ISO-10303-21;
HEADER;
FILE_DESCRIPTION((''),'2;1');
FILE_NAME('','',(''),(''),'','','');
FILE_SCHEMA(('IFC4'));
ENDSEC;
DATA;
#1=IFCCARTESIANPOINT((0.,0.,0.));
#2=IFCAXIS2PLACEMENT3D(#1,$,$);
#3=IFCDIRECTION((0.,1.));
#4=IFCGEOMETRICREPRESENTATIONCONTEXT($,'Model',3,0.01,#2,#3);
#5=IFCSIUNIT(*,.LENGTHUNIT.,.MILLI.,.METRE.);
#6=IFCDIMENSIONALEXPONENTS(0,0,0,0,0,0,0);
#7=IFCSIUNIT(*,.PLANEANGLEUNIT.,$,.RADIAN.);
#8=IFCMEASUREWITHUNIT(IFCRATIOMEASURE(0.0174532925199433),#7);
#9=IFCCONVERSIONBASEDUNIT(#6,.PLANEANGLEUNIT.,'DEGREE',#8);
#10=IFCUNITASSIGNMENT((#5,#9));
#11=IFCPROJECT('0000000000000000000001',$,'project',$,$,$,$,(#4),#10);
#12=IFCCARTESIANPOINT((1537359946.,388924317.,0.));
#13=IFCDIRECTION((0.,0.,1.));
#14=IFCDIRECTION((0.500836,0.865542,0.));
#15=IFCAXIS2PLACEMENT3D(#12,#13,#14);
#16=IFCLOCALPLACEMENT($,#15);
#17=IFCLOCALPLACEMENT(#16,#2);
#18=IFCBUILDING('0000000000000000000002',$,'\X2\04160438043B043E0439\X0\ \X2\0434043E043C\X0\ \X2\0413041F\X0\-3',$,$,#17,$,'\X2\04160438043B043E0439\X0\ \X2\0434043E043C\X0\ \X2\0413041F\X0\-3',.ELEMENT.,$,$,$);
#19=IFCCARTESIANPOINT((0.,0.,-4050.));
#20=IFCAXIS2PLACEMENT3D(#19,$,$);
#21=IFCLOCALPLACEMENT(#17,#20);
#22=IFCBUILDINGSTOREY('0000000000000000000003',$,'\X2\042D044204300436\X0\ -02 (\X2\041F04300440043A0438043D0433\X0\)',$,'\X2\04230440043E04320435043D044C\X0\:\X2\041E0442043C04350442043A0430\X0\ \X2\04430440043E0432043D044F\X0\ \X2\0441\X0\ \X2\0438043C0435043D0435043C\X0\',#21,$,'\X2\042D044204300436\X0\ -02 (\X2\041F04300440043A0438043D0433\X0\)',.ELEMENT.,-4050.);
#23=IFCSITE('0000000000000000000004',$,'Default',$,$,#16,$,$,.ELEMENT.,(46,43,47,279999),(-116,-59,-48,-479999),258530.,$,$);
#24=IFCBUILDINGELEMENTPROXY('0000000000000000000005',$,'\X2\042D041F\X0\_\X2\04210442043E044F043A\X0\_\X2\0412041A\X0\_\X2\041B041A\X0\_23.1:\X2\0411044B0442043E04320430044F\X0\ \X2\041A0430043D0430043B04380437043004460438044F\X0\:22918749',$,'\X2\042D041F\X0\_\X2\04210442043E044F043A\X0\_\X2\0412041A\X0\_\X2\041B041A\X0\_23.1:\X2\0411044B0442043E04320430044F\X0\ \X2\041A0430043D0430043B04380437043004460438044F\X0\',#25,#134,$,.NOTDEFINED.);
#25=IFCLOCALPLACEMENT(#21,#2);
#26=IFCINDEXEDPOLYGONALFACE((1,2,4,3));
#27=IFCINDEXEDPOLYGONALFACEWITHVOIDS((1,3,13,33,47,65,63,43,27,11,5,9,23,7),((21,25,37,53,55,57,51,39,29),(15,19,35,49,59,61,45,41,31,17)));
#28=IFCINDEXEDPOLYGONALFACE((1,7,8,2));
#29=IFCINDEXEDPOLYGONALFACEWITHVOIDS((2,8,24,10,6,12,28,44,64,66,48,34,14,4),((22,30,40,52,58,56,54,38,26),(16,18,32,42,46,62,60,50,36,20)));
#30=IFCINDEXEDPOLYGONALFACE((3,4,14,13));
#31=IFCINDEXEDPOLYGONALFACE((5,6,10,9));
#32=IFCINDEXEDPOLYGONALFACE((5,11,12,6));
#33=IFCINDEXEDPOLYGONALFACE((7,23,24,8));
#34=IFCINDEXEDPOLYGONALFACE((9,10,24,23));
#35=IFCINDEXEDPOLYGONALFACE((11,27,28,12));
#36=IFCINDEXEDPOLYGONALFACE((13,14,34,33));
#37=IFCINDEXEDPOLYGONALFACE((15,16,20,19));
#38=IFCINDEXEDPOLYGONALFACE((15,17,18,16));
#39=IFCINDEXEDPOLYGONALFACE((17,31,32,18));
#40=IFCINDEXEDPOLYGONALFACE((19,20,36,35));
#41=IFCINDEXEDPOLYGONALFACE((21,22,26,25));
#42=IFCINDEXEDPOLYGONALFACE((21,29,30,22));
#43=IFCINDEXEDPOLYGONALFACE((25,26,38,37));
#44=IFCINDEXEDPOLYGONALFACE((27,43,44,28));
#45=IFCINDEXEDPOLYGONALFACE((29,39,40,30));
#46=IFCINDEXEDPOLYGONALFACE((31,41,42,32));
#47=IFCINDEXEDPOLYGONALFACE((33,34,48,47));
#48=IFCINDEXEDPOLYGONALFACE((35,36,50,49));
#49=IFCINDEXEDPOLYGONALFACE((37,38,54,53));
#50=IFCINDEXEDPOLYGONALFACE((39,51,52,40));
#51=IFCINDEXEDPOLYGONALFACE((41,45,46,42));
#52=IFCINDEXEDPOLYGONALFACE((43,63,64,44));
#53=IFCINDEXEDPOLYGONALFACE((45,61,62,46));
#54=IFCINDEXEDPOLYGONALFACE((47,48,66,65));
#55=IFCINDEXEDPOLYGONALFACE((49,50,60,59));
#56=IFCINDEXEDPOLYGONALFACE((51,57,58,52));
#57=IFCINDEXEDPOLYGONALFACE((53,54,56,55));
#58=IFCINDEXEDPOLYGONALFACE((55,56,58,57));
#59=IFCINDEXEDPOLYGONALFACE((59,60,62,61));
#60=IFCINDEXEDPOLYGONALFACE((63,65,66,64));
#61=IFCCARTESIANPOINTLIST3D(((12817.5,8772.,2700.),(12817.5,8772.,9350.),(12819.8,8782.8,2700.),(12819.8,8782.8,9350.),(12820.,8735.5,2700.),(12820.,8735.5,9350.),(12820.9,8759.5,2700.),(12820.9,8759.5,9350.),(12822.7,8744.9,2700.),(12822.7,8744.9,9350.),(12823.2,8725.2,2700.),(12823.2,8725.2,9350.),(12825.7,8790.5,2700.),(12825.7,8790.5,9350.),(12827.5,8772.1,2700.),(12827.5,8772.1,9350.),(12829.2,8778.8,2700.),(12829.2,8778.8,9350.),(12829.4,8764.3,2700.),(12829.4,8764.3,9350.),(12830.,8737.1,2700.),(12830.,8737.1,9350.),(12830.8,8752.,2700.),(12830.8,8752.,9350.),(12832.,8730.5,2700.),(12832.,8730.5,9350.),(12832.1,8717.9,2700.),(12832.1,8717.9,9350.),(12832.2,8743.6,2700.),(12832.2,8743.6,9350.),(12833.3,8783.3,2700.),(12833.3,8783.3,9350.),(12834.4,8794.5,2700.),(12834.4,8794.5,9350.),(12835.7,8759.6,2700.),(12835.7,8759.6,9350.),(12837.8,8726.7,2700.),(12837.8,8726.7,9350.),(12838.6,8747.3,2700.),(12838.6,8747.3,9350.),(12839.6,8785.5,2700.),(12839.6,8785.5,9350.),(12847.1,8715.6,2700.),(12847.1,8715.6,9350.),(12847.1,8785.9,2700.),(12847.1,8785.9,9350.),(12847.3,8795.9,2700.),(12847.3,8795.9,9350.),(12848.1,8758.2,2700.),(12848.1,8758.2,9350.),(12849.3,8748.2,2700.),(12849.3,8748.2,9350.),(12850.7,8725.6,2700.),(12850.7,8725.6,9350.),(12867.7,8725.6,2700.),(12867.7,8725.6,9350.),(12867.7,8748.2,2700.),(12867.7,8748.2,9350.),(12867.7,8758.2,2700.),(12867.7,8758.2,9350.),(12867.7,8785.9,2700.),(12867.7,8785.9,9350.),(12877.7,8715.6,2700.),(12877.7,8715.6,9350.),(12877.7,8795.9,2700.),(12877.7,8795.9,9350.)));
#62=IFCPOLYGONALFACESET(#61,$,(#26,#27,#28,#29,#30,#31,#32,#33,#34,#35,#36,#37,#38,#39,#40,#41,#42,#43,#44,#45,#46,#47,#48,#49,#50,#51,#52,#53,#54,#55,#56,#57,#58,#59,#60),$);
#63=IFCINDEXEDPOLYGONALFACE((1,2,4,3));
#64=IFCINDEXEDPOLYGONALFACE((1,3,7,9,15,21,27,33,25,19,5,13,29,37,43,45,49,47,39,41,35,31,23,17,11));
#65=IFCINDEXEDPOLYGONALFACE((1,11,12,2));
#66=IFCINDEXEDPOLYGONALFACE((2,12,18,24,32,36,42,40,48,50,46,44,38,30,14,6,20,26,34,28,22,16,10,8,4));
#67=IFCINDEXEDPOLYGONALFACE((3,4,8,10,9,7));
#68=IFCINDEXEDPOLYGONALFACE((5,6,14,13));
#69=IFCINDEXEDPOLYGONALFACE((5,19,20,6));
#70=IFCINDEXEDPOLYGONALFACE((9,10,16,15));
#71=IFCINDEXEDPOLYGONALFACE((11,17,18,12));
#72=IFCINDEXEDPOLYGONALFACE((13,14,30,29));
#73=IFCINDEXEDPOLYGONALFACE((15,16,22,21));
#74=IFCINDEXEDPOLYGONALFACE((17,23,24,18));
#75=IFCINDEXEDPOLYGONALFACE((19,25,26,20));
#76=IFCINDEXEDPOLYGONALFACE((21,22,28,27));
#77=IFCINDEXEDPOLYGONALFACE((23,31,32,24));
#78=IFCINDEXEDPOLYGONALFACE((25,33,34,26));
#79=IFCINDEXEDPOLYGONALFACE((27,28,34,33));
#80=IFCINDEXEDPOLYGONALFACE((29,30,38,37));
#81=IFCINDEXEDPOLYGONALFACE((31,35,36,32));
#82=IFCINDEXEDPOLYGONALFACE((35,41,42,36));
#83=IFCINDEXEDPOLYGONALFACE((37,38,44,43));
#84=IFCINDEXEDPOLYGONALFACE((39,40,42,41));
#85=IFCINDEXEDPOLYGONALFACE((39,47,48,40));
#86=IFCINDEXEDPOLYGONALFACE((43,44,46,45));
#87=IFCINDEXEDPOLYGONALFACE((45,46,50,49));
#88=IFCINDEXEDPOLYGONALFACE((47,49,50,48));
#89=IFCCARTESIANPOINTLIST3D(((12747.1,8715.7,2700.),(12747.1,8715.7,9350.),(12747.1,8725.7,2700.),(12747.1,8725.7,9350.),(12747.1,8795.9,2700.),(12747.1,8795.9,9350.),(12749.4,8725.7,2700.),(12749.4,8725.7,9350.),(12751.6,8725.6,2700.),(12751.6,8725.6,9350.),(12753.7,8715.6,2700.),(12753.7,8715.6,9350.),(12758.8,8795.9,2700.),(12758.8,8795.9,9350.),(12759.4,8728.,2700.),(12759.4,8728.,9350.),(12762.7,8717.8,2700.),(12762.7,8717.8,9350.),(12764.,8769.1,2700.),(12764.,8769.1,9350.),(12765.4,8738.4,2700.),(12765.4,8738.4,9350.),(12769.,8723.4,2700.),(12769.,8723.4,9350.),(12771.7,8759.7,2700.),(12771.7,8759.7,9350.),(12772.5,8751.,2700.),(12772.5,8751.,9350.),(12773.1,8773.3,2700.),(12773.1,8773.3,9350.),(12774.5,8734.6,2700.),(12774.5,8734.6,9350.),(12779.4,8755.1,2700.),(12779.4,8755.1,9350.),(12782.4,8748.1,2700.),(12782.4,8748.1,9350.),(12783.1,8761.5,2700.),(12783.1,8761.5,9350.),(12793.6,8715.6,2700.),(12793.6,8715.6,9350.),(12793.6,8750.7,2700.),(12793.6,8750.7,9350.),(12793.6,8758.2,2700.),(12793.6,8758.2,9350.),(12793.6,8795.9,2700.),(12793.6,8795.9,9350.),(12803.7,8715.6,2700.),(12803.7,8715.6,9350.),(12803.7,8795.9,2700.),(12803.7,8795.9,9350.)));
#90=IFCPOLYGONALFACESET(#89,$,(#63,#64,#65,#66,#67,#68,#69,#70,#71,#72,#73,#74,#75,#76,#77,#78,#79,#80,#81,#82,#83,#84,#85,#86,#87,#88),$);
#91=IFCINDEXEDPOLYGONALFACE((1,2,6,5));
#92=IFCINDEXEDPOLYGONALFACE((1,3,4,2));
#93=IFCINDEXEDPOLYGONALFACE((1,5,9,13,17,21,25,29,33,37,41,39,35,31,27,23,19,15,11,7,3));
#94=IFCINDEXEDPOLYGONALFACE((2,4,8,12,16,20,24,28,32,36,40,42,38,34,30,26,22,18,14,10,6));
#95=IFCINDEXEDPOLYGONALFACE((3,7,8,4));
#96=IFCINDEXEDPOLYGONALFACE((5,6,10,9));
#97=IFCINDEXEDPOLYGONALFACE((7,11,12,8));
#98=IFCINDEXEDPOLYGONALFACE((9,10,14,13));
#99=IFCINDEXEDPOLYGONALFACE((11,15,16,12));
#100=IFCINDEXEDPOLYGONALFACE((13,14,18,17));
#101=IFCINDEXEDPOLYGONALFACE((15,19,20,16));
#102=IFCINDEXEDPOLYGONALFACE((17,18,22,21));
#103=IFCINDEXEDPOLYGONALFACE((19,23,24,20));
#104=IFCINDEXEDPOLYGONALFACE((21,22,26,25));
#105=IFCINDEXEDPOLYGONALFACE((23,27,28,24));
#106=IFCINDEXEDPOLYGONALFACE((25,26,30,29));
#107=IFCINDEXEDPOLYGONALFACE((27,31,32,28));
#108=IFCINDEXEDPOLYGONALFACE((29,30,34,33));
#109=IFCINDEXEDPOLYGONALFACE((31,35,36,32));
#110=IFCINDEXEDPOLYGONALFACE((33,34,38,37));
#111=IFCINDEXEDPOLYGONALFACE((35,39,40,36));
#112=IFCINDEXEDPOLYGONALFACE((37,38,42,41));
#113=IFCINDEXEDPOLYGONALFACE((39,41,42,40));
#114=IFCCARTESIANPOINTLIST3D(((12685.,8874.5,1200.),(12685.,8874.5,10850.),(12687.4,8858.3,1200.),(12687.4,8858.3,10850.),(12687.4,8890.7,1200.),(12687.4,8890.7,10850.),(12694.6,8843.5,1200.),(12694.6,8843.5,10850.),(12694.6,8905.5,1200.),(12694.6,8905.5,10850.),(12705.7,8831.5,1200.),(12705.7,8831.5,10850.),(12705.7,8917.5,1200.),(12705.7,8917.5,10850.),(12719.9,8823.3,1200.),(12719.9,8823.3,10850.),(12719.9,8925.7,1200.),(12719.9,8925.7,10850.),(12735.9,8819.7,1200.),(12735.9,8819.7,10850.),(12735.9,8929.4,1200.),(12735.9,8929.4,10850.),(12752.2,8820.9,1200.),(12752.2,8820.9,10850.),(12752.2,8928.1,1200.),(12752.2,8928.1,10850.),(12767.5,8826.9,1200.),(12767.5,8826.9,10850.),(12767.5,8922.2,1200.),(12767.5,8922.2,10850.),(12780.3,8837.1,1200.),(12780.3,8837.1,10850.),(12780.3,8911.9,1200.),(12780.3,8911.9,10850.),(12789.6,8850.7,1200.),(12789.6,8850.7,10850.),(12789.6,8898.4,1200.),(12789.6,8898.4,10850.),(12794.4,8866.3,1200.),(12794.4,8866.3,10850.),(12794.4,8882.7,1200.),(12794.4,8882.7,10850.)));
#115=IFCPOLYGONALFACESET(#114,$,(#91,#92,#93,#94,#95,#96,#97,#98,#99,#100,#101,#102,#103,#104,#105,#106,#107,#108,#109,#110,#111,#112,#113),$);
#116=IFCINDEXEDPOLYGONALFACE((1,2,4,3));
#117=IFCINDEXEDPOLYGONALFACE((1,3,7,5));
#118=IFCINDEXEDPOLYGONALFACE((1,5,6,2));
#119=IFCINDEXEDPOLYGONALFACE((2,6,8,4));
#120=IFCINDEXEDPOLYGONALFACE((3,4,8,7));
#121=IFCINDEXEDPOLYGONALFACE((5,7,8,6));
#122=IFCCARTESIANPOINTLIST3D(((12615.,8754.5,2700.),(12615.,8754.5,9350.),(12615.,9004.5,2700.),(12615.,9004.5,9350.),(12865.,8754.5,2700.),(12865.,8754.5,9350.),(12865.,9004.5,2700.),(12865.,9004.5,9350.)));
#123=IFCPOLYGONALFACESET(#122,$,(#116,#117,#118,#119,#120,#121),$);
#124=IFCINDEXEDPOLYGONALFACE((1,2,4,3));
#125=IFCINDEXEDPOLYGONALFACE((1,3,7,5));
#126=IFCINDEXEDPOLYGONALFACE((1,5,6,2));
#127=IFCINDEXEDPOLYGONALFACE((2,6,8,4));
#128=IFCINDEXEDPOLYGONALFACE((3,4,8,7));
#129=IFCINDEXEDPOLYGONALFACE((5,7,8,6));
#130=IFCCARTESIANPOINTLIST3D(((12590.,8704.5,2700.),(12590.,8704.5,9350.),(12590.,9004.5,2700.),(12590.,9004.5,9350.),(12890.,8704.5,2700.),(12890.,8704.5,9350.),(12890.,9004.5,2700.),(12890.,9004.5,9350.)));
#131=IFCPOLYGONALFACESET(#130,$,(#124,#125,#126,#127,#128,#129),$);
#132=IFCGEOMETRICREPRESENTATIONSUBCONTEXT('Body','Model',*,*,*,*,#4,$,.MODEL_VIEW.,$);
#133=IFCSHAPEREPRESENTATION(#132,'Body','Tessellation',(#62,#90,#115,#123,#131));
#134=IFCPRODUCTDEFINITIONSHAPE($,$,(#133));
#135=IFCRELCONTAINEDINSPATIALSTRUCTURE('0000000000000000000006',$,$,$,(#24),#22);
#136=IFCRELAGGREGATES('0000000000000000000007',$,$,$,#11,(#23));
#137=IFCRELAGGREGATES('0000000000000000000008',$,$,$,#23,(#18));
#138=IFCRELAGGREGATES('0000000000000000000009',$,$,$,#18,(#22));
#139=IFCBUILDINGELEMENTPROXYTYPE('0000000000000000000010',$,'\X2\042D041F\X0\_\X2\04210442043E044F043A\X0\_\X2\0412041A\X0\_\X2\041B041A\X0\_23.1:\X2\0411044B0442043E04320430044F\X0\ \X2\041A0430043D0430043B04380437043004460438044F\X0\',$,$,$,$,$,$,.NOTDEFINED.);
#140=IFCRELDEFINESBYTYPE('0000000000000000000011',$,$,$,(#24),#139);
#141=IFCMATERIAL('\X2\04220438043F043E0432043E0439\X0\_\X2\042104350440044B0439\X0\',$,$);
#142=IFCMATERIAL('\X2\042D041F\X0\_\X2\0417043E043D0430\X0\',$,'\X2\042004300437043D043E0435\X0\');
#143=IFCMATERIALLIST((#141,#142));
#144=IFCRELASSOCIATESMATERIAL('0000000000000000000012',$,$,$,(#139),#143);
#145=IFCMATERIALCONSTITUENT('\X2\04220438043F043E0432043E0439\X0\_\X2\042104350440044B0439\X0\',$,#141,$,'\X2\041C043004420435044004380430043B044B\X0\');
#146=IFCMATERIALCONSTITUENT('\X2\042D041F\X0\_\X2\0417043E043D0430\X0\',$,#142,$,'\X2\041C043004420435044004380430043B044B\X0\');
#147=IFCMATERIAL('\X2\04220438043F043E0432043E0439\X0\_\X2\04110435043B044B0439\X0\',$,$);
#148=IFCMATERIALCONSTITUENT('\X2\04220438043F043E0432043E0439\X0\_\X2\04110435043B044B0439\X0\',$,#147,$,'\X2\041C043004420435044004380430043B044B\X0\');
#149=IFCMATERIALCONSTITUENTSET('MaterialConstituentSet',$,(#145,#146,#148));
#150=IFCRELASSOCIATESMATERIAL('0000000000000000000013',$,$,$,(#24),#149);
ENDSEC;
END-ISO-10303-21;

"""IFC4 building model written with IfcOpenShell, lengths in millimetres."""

from ifc_helpers import new_model, entity, si_unit, converted_unit, direction, frame, frame_2d, origin, place, context, subcontext, project, spatial, polyline, rectangle, circle, outline, extrude, source, transform, mapped, material, material_list, constituent, constituent_set, type_object, type_shapes, element, save


model = new_model("IFC4")

# Units and contexts
model_context = context("Model", 3, precision=0.01, world=origin(), true_north=direction((0.0, 1.0)))
body_context = subcontext(model_context, "Body", "Model", "MODEL_VIEW")
ifc_project = project(units=[si_unit("LENGTHUNIT", "METRE", prefix="MILLI"), converted_unit("PLANEANGLEUNIT", "DEGREE", entity("IfcRatioMeasure", 0.0174532925199433), si_unit("PLANEANGLEUNIT", "RADIAN"), dimensions=[0, 0, 0, 0, 0, 0, 0])], contexts=[model_context])

# Site, building, storey
site_placement = place(None, frame((1537359946.0, 388924317.0, 0.0), z_axis=(0.0, 0.0, 1.0), x_axis=(0.500836, 0.865542, 0.0)))
site = spatial("IfcSite", under=ifc_project, at=site_placement, Name="Default", CompositionType="ELEMENT", RefLatitude=(46, 43, 47, 279999), RefLongitude=(-116, -59, -48, -479999), RefElevation=258530.0)
building_placement = place(site_placement, origin())
building = spatial("IfcBuilding", under=site, at=building_placement, Name="Жилой дом ГП-3", LongName="Жилой дом ГП-3", CompositionType="ELEMENT")
storey_placement = place(building_placement, frame((0.0, 0.0, -4050.0)))
storey = spatial("IfcBuildingStorey", under=building, at=storey_placement, Name="Этаж -02 (Паркинг)", ObjectType="Уровень:Отметка уровня с именем", LongName="Этаж -02 (Паркинг)", CompositionType="ELEMENT", Elevation=-4050.0)

# Building element proxy
ifc_material_1 = material(Name="ЭП_Зона", Category="Разное")
ifc_material_2 = material(Name="Типовой_Белый")
ifc_material_3 = material(Name="Типовой_Серый")
ifc_constituent_1 = constituent(ifc_material_3, Name="Типовой_Серый", Category="Материалы")
ifc_constituent_2 = constituent(ifc_material_1, Name="ЭП_Зона", Category="Материалы")
ifc_constituent_3 = constituent(ifc_material_2, Name="Типовой_Белый", Category="Материалы")
ifc_constituent_set_1 = constituent_set(constituents=[ifc_constituent_1, ifc_constituent_2, ifc_constituent_3], Name="MaterialConstituentSet")
ifc_material_list_1 = material_list([ifc_material_3, ifc_material_1])
building_element_proxy_type_1 = type_object("IfcBuildingElementProxyType", Name="ЭП_Стояк_ВК_ЛК_23.1:Бытовая Канализация", PredefinedType="NOTDEFINED", material=ifc_material_list_1)
shared_shape_1 = source(origin(), body_context, "Body", "SweptSolid", [
    extrude(outline(polyline([(-42.2, -39.0), (-11.8, -39.0), (1.1, -37.6), (9.8, -33.5), (15.7, -25.8), (18.0, -15.0), (14.6, -2.5), (4.7, 5.0), (12.8, 12.1), (15.5, 21.5), (12.3, 31.8), (3.4, 39.0), (-11.6, 41.4), (-42.2, 41.4), (-42.2, -39.0)]), holes=[polyline([(-32.2, 8.8), (-32.2, 31.4), (-15.2, 31.4), (-2.3, 30.3), (3.5, 26.4), (5.5, 19.9), (3.3, 13.3), (-3.1, 9.6), (-13.9, 8.8), (-32.2, 8.8)]), polyline([(-32.2, -28.9), (-32.2, -1.3), (-12.6, -1.3), (-0.2, -2.6), (6.1, -7.3), (8.0, -15.1), (6.3, -21.9), (2.2, -26.3), (-4.1, -28.5), (-11.6, -28.9), (-32.2, -28.9)])]), frame((54.5, -52.4, -1350.0)), (0.0, 0.0, 1.0), 6650.0),
    extrude(outline(polyline([(-32.1, -31.9), (48.3, -31.9), (48.3, -21.8), (10.6, -21.8), (13.8, -11.4), (25.6, -1.3), (48.3, 13.0), (48.3, 24.6), (21.4, 7.7), (12.0, 0.1), (7.4, -7.7), (3.3, -0.7), (-9.3, 6.4), (-19.7, 12.3), (-22.1, 20.2), (-22.0, 22.4), (-22.0, 24.6), (-32.0, 24.6), (-32.1, 18.0), (-29.9, 9.0), (-24.3, 2.8), (-13.1, -2.8), (0.4, -10.6), (3.0, -21.8), (-32.1, -21.8), (-32.1, -31.9)])), frame((118.2, -43.1, -1350.0), z_axis=(0.0, 0.0, 1.0), x_axis=(0.0, -1.0, 0.0)), (0.0, 0.0, 1.0), 6650.0),
    extrude(circle(Radius=55.0, at=frame_2d((0.0, 0.0), x_axis=(1.0, 0.0))), frame((150.0, -170.0, -2850.0)), (0.0, 0.0, 1.0), 9650.0),
    extrude(rectangle(XDim=250.0, YDim=250.0, at=frame_2d((0.0, 0.0), x_axis=(1.0, 0.0))), frame((150.0, -175.0, -1350.0)), (0.0, 0.0, 1.0), 6650.0),
    extrude(rectangle(XDim=300.0, YDim=300.0, at=frame_2d((0.0, 0.0), x_axis=(1.0, 0.0))), frame((150.0, -150.0, -1350.0)), (0.0, 0.0, 1.0), 6650.0),
])
type_shapes(building_element_proxy_type_1, [shared_shape_1])
proxy_1_placement = place(storey_placement, frame((12890.0, 8704.5, 4050.0), z_axis=(0.0, 0.0, 1.0), x_axis=(-1.0, 0.0, 0.0)))
element("IfcBuildingElementProxy", 1, at=proxy_1_placement, inside=storey, type_object=building_element_proxy_type_1, material=ifc_constituent_set_1, Name="ЭП_Стояк_ВК_ЛК_23.1:Бытовая Канализация:22918749", ObjectType="ЭП_Стояк_ВК_ЛК_23.1:Бытовая Канализация", PredefinedType="NOTDEFINED", context=body_context, shape_type="MappedRepresentation", body=[
    mapped(shared_shape_1, transform((0.0, 0.0, 0.0), scale=1.0)),
])

save(model, "model.ifc")
